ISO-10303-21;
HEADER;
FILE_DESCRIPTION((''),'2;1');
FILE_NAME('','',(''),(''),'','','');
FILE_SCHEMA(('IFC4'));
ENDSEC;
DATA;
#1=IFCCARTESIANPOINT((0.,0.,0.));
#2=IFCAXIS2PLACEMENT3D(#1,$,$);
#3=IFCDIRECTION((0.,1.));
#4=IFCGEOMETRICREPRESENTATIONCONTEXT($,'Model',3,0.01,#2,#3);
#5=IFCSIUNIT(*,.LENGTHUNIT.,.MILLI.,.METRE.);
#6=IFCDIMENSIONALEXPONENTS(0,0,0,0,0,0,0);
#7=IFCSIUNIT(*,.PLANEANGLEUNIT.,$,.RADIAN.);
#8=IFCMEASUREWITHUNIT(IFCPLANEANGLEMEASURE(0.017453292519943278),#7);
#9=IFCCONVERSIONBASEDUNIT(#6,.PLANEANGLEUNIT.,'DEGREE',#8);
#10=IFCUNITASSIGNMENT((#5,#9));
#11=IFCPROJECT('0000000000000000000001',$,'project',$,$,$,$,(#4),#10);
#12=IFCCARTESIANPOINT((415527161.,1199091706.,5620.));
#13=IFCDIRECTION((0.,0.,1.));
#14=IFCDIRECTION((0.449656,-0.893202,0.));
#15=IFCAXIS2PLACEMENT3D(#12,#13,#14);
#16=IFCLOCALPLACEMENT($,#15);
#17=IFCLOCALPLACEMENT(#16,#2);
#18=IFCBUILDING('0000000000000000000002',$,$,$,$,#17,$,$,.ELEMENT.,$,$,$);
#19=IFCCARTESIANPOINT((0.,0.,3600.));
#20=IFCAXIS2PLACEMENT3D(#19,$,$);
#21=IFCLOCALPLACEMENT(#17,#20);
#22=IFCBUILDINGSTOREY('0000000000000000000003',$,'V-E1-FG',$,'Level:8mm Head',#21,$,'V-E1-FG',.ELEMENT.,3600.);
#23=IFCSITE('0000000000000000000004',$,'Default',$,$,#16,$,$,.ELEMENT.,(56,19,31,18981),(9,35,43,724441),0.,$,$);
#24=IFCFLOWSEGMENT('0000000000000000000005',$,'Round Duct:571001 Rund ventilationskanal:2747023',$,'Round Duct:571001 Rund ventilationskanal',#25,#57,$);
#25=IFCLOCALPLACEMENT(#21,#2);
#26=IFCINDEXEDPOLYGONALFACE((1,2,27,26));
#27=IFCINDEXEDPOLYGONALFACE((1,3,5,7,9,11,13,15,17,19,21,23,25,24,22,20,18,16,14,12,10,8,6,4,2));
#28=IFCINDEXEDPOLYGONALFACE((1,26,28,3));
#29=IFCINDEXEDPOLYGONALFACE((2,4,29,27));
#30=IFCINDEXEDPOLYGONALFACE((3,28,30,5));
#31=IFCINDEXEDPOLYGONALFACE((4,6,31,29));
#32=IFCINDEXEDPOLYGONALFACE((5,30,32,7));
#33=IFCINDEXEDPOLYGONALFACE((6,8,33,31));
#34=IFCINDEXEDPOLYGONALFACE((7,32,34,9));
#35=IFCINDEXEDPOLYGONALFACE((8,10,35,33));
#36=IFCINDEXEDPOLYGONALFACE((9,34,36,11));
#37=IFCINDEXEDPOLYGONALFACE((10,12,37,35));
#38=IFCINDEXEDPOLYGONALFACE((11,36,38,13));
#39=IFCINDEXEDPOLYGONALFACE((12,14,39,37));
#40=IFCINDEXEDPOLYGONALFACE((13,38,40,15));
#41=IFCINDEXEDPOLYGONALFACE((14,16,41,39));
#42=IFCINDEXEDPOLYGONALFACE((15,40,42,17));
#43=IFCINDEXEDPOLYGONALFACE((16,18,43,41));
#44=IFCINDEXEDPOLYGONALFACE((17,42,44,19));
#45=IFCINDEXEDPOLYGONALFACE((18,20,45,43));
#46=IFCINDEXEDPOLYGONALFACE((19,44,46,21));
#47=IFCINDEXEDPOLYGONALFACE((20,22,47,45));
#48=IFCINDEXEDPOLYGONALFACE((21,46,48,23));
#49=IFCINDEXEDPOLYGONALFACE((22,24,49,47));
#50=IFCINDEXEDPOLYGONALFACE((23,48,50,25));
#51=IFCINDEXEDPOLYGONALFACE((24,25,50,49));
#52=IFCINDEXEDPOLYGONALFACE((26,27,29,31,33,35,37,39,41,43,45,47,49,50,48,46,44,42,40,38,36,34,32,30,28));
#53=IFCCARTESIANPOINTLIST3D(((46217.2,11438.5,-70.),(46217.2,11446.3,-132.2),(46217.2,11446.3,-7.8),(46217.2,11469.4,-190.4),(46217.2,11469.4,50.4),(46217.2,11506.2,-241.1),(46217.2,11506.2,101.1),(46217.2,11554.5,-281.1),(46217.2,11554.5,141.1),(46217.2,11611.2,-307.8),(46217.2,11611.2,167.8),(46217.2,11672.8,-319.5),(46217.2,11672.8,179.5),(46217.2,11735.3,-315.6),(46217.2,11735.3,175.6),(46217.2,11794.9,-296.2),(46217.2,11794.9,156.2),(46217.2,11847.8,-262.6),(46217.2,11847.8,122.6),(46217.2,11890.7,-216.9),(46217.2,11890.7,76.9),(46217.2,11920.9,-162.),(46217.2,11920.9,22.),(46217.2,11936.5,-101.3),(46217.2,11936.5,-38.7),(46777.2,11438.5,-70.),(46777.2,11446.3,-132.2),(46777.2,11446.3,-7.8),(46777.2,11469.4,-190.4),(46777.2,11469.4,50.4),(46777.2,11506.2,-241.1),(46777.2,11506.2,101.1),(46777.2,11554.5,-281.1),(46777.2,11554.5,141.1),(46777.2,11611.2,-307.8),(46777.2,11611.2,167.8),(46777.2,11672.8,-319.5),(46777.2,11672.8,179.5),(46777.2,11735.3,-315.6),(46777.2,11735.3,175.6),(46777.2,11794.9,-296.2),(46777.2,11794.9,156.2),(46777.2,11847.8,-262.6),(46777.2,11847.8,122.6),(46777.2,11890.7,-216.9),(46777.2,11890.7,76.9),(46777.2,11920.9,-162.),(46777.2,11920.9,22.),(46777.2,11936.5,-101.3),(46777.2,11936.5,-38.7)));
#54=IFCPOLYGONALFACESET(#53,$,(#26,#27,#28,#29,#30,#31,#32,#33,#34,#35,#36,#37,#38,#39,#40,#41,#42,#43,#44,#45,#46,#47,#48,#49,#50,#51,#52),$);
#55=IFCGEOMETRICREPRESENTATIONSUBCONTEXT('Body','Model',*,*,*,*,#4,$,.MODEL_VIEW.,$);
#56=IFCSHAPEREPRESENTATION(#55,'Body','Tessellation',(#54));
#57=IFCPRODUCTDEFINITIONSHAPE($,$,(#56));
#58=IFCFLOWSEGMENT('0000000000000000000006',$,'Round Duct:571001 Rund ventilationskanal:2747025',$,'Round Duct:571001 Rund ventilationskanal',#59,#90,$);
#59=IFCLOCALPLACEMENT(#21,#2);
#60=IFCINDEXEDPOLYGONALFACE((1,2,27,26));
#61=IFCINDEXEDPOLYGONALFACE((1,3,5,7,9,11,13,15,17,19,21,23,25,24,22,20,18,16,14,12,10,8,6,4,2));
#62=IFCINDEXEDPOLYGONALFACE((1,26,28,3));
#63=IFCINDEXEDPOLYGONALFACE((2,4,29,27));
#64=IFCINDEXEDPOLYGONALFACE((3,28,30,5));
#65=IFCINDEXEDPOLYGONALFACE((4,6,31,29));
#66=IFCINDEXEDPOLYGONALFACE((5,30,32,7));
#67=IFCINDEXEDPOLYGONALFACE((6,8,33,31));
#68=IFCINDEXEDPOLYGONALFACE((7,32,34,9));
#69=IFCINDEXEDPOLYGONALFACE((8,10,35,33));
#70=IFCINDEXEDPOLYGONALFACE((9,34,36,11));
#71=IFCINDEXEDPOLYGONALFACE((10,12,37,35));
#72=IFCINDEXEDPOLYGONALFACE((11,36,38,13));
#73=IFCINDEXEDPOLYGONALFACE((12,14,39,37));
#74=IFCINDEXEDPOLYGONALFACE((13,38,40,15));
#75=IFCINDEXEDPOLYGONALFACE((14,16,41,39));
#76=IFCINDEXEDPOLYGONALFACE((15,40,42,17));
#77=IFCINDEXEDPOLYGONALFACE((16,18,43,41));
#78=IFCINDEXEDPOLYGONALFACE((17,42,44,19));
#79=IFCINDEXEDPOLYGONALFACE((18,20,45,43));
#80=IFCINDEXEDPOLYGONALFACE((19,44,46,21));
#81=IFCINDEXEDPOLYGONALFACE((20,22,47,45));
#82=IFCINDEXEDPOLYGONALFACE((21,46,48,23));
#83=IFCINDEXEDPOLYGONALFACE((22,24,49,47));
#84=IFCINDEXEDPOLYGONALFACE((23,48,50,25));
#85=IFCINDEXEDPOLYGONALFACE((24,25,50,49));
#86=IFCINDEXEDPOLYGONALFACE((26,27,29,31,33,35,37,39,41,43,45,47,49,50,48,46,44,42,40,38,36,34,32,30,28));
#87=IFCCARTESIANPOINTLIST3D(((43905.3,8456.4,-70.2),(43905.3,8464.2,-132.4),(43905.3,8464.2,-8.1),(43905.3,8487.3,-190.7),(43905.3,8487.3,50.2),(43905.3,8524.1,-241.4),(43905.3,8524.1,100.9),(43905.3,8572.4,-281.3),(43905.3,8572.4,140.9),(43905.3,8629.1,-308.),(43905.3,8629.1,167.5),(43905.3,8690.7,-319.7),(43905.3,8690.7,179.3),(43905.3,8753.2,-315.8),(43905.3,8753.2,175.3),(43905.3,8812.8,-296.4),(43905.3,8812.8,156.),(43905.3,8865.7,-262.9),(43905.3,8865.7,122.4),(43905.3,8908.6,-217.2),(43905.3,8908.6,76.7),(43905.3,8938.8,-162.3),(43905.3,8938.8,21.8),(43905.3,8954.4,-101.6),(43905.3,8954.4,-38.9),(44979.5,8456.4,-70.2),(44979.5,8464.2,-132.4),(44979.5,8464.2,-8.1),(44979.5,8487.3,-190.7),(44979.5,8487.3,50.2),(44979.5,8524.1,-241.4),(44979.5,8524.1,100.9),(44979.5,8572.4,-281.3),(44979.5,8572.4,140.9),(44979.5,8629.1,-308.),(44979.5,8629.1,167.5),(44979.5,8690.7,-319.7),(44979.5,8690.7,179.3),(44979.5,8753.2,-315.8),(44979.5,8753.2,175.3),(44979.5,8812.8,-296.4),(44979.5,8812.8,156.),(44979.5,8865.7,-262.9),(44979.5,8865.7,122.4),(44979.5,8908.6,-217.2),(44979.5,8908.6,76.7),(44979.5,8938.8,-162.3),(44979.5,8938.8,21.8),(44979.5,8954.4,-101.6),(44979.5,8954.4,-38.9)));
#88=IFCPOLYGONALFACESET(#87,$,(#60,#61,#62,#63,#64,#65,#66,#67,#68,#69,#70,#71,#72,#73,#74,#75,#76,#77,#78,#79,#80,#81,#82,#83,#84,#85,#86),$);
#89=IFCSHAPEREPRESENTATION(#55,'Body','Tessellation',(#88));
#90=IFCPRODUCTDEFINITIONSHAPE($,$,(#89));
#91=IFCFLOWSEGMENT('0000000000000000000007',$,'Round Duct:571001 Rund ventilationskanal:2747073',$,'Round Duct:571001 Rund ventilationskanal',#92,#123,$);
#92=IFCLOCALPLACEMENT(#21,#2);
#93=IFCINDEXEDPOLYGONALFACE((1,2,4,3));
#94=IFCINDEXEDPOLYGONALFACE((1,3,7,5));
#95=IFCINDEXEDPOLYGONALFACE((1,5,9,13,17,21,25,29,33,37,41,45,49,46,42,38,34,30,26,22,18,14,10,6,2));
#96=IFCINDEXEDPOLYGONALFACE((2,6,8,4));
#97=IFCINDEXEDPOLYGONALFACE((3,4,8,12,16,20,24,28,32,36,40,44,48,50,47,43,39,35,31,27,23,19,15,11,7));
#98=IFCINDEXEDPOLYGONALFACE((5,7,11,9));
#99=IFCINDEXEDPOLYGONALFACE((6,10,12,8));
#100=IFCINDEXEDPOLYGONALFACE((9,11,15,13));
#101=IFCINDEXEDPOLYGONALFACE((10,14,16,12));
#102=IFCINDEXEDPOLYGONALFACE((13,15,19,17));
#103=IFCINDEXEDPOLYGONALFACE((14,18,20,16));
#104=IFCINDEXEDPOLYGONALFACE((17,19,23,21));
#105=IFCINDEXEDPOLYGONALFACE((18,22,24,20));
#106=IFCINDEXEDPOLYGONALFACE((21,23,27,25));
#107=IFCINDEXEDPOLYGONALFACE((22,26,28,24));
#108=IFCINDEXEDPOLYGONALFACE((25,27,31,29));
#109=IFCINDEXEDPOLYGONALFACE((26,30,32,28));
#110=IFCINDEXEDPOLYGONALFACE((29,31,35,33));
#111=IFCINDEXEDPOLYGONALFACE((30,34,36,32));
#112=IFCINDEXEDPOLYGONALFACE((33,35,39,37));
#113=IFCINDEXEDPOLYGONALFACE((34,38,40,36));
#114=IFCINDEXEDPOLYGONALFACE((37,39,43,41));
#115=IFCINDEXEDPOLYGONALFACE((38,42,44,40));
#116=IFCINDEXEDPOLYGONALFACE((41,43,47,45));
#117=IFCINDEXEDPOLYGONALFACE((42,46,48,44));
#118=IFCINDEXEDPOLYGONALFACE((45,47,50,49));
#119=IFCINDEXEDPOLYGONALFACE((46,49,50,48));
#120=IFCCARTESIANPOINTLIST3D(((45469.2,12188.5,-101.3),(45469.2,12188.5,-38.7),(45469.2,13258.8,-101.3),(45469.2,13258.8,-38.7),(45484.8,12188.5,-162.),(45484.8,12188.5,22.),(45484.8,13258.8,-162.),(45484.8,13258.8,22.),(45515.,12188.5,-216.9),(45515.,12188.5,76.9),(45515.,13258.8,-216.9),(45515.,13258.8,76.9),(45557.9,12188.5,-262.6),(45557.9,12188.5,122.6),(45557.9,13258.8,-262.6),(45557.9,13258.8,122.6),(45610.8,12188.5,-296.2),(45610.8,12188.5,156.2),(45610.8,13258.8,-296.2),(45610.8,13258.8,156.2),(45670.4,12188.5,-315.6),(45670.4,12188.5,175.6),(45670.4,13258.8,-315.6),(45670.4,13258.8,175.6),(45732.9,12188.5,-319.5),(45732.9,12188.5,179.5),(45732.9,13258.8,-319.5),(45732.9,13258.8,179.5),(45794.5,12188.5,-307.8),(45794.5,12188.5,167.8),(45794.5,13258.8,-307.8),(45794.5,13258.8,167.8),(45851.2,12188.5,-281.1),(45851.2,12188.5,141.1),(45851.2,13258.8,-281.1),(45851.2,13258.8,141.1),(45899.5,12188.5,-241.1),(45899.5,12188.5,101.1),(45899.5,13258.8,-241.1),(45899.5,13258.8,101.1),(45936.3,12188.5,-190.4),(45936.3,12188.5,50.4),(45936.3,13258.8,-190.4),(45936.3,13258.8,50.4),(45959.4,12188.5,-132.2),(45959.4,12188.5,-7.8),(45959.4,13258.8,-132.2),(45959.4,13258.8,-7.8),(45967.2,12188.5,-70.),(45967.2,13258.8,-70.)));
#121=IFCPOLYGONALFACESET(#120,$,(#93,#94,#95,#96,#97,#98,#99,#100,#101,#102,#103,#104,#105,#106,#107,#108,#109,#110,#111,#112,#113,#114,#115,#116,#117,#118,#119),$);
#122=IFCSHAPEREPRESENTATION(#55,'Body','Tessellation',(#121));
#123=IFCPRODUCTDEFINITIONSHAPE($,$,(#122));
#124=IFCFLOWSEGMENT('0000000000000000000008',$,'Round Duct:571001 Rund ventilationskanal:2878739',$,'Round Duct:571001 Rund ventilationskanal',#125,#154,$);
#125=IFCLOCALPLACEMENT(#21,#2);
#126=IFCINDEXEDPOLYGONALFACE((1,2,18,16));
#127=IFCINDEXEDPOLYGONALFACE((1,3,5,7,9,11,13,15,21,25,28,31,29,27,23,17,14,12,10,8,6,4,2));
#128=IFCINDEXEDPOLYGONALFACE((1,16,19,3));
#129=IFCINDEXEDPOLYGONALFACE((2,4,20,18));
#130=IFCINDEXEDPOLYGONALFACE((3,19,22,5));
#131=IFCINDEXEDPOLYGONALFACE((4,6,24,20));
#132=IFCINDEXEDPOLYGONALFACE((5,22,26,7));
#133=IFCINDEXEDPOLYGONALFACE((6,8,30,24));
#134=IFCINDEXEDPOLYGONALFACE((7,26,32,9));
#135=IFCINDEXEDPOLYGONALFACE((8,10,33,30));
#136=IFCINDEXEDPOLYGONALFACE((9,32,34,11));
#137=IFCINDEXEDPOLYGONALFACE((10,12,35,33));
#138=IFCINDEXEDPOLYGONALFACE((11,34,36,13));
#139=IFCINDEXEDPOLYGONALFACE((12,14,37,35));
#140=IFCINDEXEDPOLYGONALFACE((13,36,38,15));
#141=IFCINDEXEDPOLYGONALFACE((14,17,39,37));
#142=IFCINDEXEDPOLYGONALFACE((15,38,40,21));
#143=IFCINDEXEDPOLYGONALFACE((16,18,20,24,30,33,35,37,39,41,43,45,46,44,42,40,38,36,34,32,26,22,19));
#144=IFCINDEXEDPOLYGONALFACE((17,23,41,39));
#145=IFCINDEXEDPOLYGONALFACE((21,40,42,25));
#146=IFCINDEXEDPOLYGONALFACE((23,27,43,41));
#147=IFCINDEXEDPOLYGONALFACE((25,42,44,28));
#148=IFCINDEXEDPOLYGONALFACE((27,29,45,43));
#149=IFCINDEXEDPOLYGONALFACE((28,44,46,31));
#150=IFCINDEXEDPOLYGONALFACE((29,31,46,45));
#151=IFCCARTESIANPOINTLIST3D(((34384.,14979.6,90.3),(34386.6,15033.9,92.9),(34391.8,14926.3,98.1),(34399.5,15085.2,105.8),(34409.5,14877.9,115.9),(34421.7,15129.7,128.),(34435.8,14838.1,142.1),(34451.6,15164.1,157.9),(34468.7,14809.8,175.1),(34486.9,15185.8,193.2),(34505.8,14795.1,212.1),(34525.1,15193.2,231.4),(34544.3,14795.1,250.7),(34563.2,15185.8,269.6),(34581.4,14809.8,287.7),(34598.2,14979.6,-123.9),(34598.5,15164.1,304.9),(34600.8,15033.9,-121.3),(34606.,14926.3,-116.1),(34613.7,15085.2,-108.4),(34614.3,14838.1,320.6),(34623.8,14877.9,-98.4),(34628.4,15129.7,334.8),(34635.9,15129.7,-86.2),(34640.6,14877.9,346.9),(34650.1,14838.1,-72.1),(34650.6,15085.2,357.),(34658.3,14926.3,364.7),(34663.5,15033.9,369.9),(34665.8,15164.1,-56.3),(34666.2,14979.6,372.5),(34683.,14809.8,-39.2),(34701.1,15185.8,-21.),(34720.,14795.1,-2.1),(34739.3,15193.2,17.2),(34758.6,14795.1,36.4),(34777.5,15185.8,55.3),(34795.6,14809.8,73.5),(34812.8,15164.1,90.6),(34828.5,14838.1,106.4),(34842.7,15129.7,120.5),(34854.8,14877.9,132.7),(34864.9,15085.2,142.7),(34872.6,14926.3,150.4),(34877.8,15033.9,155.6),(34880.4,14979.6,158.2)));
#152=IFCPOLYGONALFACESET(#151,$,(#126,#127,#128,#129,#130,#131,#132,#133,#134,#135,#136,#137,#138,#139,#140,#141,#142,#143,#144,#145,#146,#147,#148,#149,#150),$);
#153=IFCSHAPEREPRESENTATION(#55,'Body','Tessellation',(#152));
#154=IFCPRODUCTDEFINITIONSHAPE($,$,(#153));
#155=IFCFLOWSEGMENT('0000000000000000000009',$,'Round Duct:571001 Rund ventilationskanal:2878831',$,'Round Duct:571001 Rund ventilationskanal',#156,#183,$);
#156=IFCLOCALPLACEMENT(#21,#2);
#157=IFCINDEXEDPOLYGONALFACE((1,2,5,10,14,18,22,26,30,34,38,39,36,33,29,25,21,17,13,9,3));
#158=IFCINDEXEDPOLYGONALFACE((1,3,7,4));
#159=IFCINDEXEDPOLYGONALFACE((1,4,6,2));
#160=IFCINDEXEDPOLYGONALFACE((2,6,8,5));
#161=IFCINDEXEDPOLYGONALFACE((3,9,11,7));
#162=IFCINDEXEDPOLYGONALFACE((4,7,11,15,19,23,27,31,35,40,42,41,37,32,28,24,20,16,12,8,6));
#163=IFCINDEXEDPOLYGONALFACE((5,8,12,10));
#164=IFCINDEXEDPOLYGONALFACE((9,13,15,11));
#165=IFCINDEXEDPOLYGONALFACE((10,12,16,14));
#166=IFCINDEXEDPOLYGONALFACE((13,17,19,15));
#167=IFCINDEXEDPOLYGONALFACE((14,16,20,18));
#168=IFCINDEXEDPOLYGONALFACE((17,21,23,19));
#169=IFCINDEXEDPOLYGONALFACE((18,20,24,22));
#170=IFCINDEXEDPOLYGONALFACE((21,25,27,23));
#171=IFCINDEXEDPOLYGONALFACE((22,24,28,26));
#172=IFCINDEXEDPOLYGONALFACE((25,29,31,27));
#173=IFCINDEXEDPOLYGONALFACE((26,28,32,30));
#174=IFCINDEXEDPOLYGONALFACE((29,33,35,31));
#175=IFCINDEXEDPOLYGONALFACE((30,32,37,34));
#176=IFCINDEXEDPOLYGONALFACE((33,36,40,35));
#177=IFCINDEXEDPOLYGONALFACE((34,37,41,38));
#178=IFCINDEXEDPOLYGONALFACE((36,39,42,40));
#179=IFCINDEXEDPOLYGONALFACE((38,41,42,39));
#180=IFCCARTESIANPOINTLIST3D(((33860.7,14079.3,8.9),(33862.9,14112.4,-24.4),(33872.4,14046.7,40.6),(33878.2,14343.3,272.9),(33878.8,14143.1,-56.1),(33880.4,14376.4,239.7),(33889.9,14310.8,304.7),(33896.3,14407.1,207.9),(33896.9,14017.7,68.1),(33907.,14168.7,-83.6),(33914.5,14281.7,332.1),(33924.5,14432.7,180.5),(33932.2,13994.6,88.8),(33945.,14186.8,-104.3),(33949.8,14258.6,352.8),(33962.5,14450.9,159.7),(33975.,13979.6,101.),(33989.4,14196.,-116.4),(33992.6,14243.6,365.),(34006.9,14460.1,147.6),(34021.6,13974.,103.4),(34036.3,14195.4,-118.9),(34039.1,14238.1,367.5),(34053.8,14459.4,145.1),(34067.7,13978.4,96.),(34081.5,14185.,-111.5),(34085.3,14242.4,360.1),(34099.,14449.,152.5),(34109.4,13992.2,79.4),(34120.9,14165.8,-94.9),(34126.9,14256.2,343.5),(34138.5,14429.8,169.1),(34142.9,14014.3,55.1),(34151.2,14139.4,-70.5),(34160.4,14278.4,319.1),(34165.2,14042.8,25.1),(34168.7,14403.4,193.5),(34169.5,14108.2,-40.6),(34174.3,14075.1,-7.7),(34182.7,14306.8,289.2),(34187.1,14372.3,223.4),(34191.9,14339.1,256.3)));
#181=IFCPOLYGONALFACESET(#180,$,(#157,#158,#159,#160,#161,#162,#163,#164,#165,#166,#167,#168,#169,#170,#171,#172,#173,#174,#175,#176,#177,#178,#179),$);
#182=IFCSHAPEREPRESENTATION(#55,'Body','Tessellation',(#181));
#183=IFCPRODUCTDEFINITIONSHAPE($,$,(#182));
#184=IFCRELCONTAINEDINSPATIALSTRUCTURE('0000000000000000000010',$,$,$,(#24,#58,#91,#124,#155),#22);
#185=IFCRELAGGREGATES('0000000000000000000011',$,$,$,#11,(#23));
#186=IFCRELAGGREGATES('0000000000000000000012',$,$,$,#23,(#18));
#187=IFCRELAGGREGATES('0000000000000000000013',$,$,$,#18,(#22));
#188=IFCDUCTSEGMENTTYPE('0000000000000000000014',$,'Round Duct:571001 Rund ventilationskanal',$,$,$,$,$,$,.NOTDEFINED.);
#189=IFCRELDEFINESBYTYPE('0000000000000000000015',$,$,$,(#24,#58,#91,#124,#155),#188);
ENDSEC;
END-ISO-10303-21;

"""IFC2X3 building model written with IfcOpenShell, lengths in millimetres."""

from ifc_helpers import new_model, entity, si_unit, converted_unit, direction, frame, frame_2d, origin, origin_2d_with_axis, place, context, subcontext, project, spatial, circle, extrude, type_object, element, save


model = new_model("IFC2X3")

# Units and contexts
model_context = context("Model", 3, precision=0.01, world=origin(), true_north=direction((0.0, 1.0)))
body_context = subcontext(model_context, "Body", "Model", "MODEL_VIEW")
ifc_project = project(units=[si_unit("LENGTHUNIT", "METRE", prefix="MILLI"), converted_unit("PLANEANGLEUNIT", "DEGREE", entity("IfcPlaneAngleMeasure", 0.017453292519943278), si_unit("PLANEANGLEUNIT", "RADIAN"), dimensions=[0, 0, 0, 0, 0, 0, 0])], contexts=[model_context])

# Site, building, storey
site_placement = place(None, frame((415527161.0, 1199091706.0, 5620.0), z_axis=(0.0, 0.0, 1.0), x_axis=(0.449656, -0.893202, 0.0)))
site = spatial("IfcSite", under=ifc_project, at=site_placement, Name="Default", CompositionType="ELEMENT", RefLatitude=(56, 19, 31, 18981), RefLongitude=(9, 35, 43, 724441), RefElevation=0.0)
building_placement = place(site_placement, origin())
building = spatial("IfcBuilding", under=site, at=building_placement, CompositionType="ELEMENT")
storey_placement = place(building_placement, frame((0.0, 0.0, 3600.0)))
storey = spatial("IfcBuildingStorey", under=building, at=storey_placement, Name="V-E1-FG", ObjectType="Level:8mm Head", LongName="V-E1-FG", CompositionType="ELEMENT", Elevation=3600.0)

# Flow segments
duct_segment_type = type_object("IfcDuctSegmentType", Name="Round Duct:571001 Rund ventilationskanal", PredefinedType="NOTDEFINED")
flow_segment_1_placement = place(storey_placement, origin())
element("IfcFlowSegment", 1, at=flow_segment_1_placement, inside=storey, type_object=duct_segment_type, Name="Round Duct:571001 Rund ventilationskanal:2747023", ObjectType="Round Duct:571001 Rund ventilationskanal", context=body_context, shape_type="SweptSolid", body=[
    extrude(circle(Radius=250.0, at=frame_2d((0.0, 0.0), x_axis=(1.0, 0.0))), frame((46217.2, 11688.5, -70.0), z_axis=(1.0, 0.0, 0.0), x_axis=(0.0, -1.0, 0.0)), (0.0, 0.0, 1.0), 560.0),
])
flow_segment_2_placement = place(storey_placement, origin())
element("IfcFlowSegment", 2, at=flow_segment_2_placement, inside=storey, type_object=duct_segment_type, Name="Round Duct:571001 Rund ventilationskanal:2747025", ObjectType="Round Duct:571001 Rund ventilationskanal", context=body_context, shape_type="SweptSolid", body=[
    extrude(circle(Radius=250.0, at=frame_2d((0.0, 0.0), x_axis=(1.0, 0.0))), frame((43905.3, 8706.4, -70.2), z_axis=(1.0, 0.0, 0.0), x_axis=(0.0, -1.0, 0.0)), (0.0, 0.0, 1.0), 1074.2),
])
flow_segment_3_placement = place(storey_placement, origin())
element("IfcFlowSegment", 3, at=flow_segment_3_placement, inside=storey, type_object=duct_segment_type, Name="Round Duct:571001 Rund ventilationskanal:2747073", ObjectType="Round Duct:571001 Rund ventilationskanal", context=body_context, shape_type="SweptSolid", body=[
    extrude(circle(Radius=250.0, at=origin_2d_with_axis()), frame((45717.2, 12188.5, -70.0), z_axis=(0.0, 1.0, 0.0), x_axis=(1.0, 0.0, 0.0)), (0.0, 0.0, 1.0), 1070.3),
])
flow_segment_4_placement = place(storey_placement, origin())
element("IfcFlowSegment", 4, at=flow_segment_4_placement, inside=storey, type_object=duct_segment_type, Name="Round Duct:571001 Rund ventilationskanal:2878739", ObjectType="Round Duct:571001 Rund ventilationskanal", context=body_context, shape_type="SweptSolid", body=[
    extrude(circle(Radius=200.0, at=frame_2d((0.0, 0.0), x_axis=(1.0, 0.0))), frame((34525.1, 14993.2, 231.4), z_axis=(0.707107, 0.0, -0.707107), x_axis=(0.0, 1.0, 0.0)), (0.0, 0.0, 1.0), 303.0),
])
flow_segment_5_placement = place(storey_placement, origin())
element("IfcFlowSegment", 5, at=flow_segment_5_placement, inside=storey, type_object=duct_segment_type, Name="Round Duct:571001 Rund ventilationskanal:2878831", ObjectType="Round Duct:571001 Rund ventilationskanal", context=body_context, shape_type="SweptSolid", body=[
    extrude(circle(Radius=157.5, at=origin_2d_with_axis()), frame((34017.2, 14085.5, -7.7), z_axis=(0.046951, 0.706327, 0.706327), x_axis=(0.997798, -0.066325, 0.0)), (0.0, 0.0, 1.0), 373.8),
])

save(model, "model.ifc")
